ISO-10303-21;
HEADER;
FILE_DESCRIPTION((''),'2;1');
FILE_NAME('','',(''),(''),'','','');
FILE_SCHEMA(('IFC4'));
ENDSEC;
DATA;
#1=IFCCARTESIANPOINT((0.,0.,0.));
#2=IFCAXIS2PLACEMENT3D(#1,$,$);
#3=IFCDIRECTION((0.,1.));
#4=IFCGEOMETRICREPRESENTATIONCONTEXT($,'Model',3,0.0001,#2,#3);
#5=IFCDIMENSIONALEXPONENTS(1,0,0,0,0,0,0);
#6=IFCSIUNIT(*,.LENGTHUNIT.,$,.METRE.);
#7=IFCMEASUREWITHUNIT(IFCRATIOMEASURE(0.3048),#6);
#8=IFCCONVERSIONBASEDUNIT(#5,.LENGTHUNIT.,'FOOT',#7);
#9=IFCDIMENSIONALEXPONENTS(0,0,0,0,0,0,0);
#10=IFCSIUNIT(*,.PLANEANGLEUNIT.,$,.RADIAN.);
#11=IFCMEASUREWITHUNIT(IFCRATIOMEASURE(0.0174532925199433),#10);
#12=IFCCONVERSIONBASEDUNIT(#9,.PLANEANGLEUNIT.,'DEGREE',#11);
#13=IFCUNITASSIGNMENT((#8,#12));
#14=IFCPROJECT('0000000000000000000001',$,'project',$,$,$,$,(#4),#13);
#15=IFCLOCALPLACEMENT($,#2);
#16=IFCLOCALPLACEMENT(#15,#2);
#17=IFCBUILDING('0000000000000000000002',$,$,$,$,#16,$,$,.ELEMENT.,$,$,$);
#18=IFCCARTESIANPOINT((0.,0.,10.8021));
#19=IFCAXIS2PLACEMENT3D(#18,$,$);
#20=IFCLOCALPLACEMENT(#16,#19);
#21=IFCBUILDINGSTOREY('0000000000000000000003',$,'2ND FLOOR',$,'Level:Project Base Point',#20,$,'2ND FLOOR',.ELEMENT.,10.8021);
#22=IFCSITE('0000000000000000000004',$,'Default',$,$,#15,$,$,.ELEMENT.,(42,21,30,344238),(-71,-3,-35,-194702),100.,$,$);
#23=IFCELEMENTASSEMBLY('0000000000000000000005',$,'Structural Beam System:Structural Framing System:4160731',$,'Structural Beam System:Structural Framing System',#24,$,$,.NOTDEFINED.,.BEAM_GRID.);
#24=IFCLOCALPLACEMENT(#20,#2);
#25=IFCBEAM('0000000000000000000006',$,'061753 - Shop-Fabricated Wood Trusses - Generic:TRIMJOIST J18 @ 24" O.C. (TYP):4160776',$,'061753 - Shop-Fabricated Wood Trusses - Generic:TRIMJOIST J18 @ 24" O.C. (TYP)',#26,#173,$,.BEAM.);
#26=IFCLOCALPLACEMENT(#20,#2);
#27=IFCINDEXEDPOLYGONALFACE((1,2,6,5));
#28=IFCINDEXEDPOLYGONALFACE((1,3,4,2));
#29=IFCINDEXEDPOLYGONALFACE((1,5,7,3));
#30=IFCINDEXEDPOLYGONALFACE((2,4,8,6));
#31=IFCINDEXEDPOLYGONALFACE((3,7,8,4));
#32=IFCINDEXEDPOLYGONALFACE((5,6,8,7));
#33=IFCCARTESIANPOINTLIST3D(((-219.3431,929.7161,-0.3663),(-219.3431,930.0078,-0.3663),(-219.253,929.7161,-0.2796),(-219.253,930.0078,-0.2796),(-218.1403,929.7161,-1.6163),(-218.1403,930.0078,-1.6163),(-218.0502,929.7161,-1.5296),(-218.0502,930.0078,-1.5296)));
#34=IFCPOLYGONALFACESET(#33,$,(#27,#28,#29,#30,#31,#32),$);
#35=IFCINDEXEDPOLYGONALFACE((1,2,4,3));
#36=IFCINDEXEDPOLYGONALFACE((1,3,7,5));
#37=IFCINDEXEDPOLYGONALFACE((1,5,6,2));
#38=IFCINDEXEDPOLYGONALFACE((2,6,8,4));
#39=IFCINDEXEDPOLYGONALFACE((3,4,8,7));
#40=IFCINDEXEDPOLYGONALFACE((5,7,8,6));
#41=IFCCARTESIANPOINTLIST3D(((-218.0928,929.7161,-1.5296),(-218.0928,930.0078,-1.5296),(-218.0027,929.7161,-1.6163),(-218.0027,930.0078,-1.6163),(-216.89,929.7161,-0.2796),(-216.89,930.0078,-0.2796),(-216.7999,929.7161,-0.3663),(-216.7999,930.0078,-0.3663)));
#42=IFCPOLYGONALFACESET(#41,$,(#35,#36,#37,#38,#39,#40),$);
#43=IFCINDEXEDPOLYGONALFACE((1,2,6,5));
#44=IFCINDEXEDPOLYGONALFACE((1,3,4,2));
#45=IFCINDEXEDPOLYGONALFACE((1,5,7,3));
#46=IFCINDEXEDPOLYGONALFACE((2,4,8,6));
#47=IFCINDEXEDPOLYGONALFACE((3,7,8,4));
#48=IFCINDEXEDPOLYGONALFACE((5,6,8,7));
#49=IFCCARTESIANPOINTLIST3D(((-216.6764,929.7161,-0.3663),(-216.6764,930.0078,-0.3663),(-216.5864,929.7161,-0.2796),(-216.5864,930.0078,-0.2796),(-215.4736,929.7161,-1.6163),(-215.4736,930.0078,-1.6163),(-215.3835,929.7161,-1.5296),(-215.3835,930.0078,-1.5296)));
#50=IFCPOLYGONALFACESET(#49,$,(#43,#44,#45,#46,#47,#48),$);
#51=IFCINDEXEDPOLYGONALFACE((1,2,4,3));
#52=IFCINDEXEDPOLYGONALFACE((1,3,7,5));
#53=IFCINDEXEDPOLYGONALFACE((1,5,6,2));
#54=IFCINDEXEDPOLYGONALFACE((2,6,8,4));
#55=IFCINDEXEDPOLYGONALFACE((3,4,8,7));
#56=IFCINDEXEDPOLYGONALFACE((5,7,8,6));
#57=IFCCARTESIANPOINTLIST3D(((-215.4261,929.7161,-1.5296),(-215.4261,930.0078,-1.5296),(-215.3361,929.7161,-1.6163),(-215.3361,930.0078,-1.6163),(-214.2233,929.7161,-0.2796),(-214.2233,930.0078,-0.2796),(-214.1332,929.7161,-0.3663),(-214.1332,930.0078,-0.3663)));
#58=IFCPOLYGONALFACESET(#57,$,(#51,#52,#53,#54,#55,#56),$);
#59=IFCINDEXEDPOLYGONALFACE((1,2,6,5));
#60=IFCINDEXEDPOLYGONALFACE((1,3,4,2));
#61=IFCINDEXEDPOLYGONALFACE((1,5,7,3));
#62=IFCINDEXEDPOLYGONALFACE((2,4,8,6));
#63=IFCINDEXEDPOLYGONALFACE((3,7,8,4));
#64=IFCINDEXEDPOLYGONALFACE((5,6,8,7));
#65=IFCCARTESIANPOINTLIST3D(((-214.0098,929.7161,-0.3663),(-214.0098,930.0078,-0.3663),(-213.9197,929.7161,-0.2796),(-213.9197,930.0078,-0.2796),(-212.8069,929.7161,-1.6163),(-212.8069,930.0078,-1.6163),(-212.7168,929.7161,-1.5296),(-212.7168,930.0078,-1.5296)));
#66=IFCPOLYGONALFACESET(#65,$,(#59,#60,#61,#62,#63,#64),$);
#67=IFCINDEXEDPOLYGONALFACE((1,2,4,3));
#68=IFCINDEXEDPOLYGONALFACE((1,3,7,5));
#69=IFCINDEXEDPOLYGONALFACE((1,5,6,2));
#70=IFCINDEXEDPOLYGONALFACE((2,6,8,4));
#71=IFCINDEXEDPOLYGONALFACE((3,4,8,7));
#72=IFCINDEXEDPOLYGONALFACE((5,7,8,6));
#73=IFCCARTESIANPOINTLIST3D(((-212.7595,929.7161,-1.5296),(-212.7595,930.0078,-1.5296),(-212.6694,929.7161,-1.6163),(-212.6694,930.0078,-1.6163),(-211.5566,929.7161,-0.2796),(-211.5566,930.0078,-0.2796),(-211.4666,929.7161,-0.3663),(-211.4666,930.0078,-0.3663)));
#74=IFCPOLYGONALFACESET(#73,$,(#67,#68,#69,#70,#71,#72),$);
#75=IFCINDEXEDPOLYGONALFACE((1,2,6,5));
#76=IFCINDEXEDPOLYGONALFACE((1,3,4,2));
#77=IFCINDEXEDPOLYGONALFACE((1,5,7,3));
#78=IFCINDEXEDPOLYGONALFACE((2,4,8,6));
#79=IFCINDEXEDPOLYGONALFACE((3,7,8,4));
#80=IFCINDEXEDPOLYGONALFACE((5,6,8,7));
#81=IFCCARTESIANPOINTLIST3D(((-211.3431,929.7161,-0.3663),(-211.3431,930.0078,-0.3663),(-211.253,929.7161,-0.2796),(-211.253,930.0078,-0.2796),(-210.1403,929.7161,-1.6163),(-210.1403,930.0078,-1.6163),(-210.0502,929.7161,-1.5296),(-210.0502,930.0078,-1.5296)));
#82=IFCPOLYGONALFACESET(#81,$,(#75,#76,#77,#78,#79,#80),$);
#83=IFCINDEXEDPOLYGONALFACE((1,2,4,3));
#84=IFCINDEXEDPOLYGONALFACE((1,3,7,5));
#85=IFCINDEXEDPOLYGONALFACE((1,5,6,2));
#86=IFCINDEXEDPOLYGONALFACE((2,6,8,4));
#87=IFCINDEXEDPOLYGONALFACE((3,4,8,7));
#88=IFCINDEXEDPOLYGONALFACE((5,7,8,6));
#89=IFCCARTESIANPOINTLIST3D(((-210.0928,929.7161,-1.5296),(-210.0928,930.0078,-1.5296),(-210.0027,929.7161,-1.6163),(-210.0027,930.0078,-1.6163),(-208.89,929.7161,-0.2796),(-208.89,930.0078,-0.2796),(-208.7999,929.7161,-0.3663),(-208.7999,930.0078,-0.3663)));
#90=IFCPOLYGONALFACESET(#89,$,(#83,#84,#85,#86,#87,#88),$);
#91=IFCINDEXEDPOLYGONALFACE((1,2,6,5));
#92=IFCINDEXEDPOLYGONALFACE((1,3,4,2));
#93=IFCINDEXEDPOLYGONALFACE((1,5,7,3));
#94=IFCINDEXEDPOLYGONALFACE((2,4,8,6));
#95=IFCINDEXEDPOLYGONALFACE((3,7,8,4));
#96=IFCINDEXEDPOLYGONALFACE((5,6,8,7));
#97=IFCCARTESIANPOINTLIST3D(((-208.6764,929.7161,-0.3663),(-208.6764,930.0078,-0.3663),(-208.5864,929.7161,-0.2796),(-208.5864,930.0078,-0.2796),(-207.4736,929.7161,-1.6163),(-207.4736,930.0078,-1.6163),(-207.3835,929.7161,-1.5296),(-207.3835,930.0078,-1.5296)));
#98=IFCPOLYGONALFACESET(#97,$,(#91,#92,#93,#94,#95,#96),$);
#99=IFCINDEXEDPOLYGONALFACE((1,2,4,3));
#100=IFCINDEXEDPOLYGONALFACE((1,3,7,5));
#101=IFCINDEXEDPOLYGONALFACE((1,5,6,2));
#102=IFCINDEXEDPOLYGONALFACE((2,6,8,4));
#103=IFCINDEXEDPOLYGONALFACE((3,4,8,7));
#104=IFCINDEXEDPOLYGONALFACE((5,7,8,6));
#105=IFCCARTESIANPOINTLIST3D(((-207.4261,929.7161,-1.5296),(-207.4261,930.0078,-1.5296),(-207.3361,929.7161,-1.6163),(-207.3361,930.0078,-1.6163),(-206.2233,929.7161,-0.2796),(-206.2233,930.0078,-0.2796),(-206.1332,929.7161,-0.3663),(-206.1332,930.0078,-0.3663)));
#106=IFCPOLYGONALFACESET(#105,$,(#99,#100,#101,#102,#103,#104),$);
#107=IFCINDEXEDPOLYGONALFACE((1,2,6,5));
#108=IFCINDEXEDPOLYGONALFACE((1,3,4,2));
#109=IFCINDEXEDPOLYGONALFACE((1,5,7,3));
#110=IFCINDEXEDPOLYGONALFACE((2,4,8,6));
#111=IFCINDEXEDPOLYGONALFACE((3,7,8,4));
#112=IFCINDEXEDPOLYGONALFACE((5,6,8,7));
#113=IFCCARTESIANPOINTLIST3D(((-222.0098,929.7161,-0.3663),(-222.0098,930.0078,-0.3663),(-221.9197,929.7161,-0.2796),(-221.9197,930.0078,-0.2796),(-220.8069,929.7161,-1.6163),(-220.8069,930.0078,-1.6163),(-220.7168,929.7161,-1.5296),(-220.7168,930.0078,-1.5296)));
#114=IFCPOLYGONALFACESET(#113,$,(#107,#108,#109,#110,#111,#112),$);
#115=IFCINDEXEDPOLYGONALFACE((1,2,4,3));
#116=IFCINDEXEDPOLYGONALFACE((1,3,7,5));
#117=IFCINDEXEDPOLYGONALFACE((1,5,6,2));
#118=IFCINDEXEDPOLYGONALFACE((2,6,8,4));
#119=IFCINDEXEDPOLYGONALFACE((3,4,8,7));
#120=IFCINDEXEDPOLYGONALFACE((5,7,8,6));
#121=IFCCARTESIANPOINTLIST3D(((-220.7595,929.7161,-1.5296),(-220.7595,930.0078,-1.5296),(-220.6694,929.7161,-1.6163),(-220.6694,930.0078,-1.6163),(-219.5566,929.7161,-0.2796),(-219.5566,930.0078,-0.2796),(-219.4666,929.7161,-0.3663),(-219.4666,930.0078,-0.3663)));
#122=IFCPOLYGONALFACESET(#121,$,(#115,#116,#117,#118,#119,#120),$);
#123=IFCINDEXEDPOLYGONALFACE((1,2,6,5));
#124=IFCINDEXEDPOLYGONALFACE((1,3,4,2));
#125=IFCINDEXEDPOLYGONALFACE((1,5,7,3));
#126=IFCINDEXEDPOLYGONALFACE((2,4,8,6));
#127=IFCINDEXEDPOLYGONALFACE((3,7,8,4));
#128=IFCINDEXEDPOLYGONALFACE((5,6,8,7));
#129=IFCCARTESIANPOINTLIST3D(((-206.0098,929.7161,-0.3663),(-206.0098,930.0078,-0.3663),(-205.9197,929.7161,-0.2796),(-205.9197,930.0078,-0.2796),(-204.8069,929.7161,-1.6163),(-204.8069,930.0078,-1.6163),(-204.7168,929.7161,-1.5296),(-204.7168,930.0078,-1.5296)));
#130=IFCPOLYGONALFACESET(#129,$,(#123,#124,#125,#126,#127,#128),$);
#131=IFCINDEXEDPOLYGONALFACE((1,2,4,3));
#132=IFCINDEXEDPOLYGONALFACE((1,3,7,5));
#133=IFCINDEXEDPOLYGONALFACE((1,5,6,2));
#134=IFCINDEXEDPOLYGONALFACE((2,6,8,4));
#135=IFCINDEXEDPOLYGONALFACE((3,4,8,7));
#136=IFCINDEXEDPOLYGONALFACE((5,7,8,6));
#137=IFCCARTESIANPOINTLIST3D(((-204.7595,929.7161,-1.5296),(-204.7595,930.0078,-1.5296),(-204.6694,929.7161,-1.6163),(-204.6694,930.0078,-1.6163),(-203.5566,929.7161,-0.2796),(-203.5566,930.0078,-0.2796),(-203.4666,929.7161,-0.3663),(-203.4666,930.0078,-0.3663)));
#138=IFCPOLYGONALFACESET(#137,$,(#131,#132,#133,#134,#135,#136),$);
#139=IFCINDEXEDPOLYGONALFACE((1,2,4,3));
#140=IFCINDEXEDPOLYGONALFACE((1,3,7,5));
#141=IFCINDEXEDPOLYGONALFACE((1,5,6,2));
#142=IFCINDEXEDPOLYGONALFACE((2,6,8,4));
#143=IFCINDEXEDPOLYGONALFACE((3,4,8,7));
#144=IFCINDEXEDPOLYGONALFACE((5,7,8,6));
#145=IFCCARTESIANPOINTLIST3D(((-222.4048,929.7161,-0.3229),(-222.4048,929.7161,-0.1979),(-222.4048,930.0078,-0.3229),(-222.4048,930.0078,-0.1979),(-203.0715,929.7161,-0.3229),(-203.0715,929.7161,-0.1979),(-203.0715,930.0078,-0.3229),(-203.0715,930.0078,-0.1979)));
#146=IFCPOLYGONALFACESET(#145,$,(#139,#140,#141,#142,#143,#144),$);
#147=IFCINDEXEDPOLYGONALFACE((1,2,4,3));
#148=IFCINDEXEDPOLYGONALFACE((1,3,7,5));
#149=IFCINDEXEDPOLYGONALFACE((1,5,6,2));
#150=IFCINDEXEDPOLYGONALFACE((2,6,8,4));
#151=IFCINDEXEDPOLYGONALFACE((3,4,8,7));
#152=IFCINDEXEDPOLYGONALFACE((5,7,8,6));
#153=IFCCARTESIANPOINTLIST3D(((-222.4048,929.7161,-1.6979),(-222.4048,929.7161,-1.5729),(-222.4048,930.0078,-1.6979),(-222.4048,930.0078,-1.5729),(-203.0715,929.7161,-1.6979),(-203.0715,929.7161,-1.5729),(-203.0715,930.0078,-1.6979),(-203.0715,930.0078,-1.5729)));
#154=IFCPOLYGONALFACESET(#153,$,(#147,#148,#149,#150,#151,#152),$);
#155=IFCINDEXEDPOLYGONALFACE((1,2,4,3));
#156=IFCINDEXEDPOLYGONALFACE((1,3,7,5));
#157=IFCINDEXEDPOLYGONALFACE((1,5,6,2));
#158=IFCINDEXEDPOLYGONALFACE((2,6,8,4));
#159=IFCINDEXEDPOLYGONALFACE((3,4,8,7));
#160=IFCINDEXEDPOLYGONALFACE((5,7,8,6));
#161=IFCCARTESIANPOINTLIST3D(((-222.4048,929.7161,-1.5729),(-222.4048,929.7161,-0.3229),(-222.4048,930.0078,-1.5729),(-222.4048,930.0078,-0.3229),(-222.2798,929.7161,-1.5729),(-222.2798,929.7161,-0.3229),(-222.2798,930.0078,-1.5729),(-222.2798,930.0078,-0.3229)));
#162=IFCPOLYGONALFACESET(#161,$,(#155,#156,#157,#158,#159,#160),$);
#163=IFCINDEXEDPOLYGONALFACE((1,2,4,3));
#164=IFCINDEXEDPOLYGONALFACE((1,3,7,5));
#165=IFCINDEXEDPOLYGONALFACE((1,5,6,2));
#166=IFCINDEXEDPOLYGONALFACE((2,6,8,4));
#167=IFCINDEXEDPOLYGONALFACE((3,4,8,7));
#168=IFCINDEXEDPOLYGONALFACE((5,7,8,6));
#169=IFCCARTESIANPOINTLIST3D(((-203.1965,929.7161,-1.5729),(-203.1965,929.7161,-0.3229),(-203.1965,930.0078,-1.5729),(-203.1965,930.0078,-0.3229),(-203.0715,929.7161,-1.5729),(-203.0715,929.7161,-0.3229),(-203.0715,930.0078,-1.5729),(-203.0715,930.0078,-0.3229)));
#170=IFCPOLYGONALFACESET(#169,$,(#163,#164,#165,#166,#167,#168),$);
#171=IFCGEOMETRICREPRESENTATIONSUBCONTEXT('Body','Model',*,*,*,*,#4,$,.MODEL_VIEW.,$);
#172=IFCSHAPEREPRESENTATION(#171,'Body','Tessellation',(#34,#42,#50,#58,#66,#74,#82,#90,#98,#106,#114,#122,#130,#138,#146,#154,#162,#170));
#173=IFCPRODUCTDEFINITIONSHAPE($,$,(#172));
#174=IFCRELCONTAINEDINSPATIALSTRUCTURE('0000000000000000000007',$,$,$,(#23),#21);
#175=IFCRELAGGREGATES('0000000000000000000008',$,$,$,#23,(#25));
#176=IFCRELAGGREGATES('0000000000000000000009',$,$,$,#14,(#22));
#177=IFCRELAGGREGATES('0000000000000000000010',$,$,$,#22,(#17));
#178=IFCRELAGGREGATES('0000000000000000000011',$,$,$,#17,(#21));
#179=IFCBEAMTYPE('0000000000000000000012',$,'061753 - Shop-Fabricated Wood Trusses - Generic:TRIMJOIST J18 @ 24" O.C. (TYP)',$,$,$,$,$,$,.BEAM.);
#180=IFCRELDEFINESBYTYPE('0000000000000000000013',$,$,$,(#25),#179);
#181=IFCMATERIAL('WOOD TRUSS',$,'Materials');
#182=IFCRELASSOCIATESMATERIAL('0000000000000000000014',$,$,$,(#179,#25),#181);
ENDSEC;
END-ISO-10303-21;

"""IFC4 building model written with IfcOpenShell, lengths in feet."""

from ifc_helpers import new_model, entity, si_unit, converted_unit, direction, frame, frame_2d, origin, origin_2d_with_axis, place, context, subcontext, project, spatial, rectangle, extrude, source, transform, mapped, material, material_profile, profile_set, profile_usage, type_object, type_shapes, element, aggregate, save


model = new_model("IFC4")

# Units and contexts
model_context = context("Model", 3, precision=0.0001, world=origin(), true_north=direction((0.0, 1.0)))
body_context = subcontext(model_context, "Body", "Model", "MODEL_VIEW")
ifc_project = project(units=[converted_unit("LENGTHUNIT", "FOOT", entity("IfcRatioMeasure", 0.3048), si_unit("LENGTHUNIT", "METRE"), dimensions=[1, 0, 0, 0, 0, 0, 0]), converted_unit("PLANEANGLEUNIT", "DEGREE", entity("IfcRatioMeasure", 0.0174532925199433), si_unit("PLANEANGLEUNIT", "RADIAN"), dimensions=[0, 0, 0, 0, 0, 0, 0])], contexts=[model_context])

# Site, building, storey
site_placement = place(None, origin())
site = spatial("IfcSite", under=ifc_project, at=site_placement, Name="Default", CompositionType="ELEMENT", RefLatitude=(42, 21, 30, 344238), RefLongitude=(-71, -3, -35, -194702), RefElevation=100.0)
building_placement = place(site_placement, origin())
building = spatial("IfcBuilding", under=site, at=building_placement, CompositionType="ELEMENT")
storey_placement = place(building_placement, frame((0.0, 0.0, 10.8021)))
storey = spatial("IfcBuildingStorey", under=building, at=storey_placement, Name="2ND FLOOR", ObjectType="Level:Project Base Point", LongName="2ND FLOOR", CompositionType="ELEMENT", Elevation=10.8021)

# Element assembly, beam
ifc_material_1 = material(Name="WOOD TRUSS", Category="Materials")
ifc_material_profile_1 = material_profile(ifc_material_1, rectangle(XDim=1.7347, YDim=0.125, at=frame_2d((0.0, 0.0), x_axis=(1.0, 0.0))), Name="TRIMJOIST J18 @ 24\" O.C. (TYP)")
ifc_material_profile_2 = material_profile(ifc_material_1, rectangle(XDim=1.7347, YDim=0.125, at=frame_2d((0.0, 0.0), x_axis=(1.0, 0.0))), Name="TRIMJOIST J18 @ 24\" O.C. (TYP)")
ifc_material_profile_3 = material_profile(ifc_material_1, rectangle(XDim=1.7347, YDim=0.125, at=frame_2d((0.0, 0.0), x_axis=(1.0, 0.0))), Name="TRIMJOIST J18 @ 24\" O.C. (TYP)")
ifc_material_profile_4 = material_profile(ifc_material_1, rectangle(XDim=1.7347, YDim=0.125, at=frame_2d((0.0, 0.0), x_axis=(1.0, 0.0))), Name="TRIMJOIST J18 @ 24\" O.C. (TYP)")
ifc_material_profile_5 = material_profile(ifc_material_1, rectangle(XDim=1.7347, YDim=0.125, at=frame_2d((0.0, 0.0), x_axis=(1.0, 0.0))), Name="TRIMJOIST J18 @ 24\" O.C. (TYP)")
ifc_material_profile_6 = material_profile(ifc_material_1, rectangle(XDim=1.7347, YDim=0.125, at=frame_2d((0.0, 0.0), x_axis=(1.0, 0.0))), Name="TRIMJOIST J18 @ 24\" O.C. (TYP)")
ifc_material_profile_7 = material_profile(ifc_material_1, rectangle(XDim=1.7347, YDim=0.125, at=frame_2d((0.0, 0.0), x_axis=(1.0, 0.0))), Name="TRIMJOIST J18 @ 24\" O.C. (TYP)")
ifc_material_profile_8 = material_profile(ifc_material_1, rectangle(XDim=1.7347, YDim=0.125, at=frame_2d((0.0, 0.0), x_axis=(1.0, 0.0))), Name="TRIMJOIST J18 @ 24\" O.C. (TYP)")
ifc_material_profile_9 = material_profile(ifc_material_1, rectangle(XDim=1.7347, YDim=0.125, at=frame_2d((0.0, 0.0), x_axis=(1.0, 0.0))), Name="TRIMJOIST J18 @ 24\" O.C. (TYP)")
ifc_material_profile_10 = material_profile(ifc_material_1, rectangle(XDim=1.7347, YDim=0.125, at=origin_2d_with_axis()), Name="TRIMJOIST J18 @ 24\" O.C. (TYP)")
ifc_material_profile_11 = material_profile(ifc_material_1, rectangle(XDim=0.125, YDim=0.2917, at=origin_2d_with_axis()), Name="TRIMJOIST J18 @ 24\" O.C. (TYP)")
ifc_material_profile_12 = material_profile(ifc_material_1, rectangle(XDim=0.125, YDim=0.2917, at=origin_2d_with_axis()), Name="TRIMJOIST J18 @ 24\" O.C. (TYP)")
ifc_material_profile_13 = material_profile(ifc_material_1, rectangle(XDim=1.25, YDim=0.2917, at=origin_2d_with_axis()), Name="TRIMJOIST J18 @ 24\" O.C. (TYP)")
ifc_material_profile_14 = material_profile(ifc_material_1, rectangle(XDim=1.25, YDim=0.2917, at=origin_2d_with_axis()), Name="TRIMJOIST J18 @ 24\" O.C. (TYP)")
ifc_profile_set_1 = profile_set([ifc_material_profile_1, ifc_material_profile_2, ifc_material_profile_3, ifc_material_profile_4, ifc_material_profile_5, ifc_material_profile_6, ifc_material_profile_7, ifc_material_profile_8, ifc_material_profile_9, ifc_material_profile_10, ifc_material_profile_11, ifc_material_profile_12, ifc_material_profile_13, ifc_material_profile_14], Name="TRIMJOIST J18 @ 24\" O.C. (TYP)")
beam_type_1 = type_object("IfcBeamType", Name="061753 - Shop-Fabricated Wood Trusses - Generic:TRIMJOIST J18 @ 24\" O.C. (TYP)", PredefinedType="BEAM", material=ifc_profile_set_1)
shared_shape_1 = source(origin(), body_context, "Body", "SweptSolid", [
    extrude(rectangle(XDim=1.7347, YDim=0.125, at=frame_2d((0.0, 0.0), x_axis=(1.0, 0.0))), frame((5.9585, -0.1458, 0.0), z_axis=(0.0, 1.0, 0.0), x_axis=(0.693383, 0.0, 0.720569)), (0.0, 0.0, 1.0), 0.2917),
    extrude(rectangle(XDim=1.7347, YDim=0.125, at=origin_2d_with_axis()), frame((4.7082, -0.1458, 0.0), z_axis=(0.0, 1.0, 0.0), x_axis=(0.693383, 0.0, -0.720569)), (0.0, 0.0, 1.0), 0.2917),
    extrude(rectangle(XDim=1.7347, YDim=0.125, at=frame_2d((0.0, 0.0), x_axis=(1.0, 0.0))), frame((3.2918, -0.1458, 0.0), z_axis=(0.0, 1.0, 0.0), x_axis=(0.693383, 0.0, 0.720569)), (0.0, 0.0, 1.0), 0.2917),
    extrude(rectangle(XDim=1.7347, YDim=0.125, at=frame_2d((0.0, 0.0), x_axis=(1.0, 0.0))), frame((2.0415, -0.1458, 0.0), z_axis=(0.0, 1.0, 0.0), x_axis=(0.693383, 0.0, -0.720569)), (0.0, 0.0, 1.0), 0.2917),
    extrude(rectangle(XDim=1.7347, YDim=0.125, at=frame_2d((0.0, 0.0), x_axis=(1.0, 0.0))), frame((0.6251, -0.1458, 0.0), z_axis=(0.0, 1.0, 0.0), x_axis=(0.693383, 0.0, 0.720569)), (0.0, 0.0, 1.0), 0.2917),
    extrude(rectangle(XDim=1.7347, YDim=0.125, at=frame_2d((0.0, 0.0), x_axis=(1.0, 0.0))), frame((-0.6251, -0.1458, 0.0), z_axis=(0.0, 1.0, 0.0), x_axis=(0.693383, 0.0, -0.720569)), (0.0, 0.0, 1.0), 0.2917),
    extrude(rectangle(XDim=1.7347, YDim=0.125, at=frame_2d((0.0, 0.0), x_axis=(1.0, 0.0))), frame((-2.0415, -0.1458, 0.0), z_axis=(0.0, 1.0, 0.0), x_axis=(0.693383, 0.0, 0.720569)), (0.0, 0.0, 1.0), 0.2917),
    extrude(rectangle(XDim=1.7347, YDim=0.125, at=origin_2d_with_axis()), frame((-3.2918, -0.1458, 0.0), z_axis=(0.0, 1.0, 0.0), x_axis=(0.693383, 0.0, -0.720569)), (0.0, 0.0, 1.0), 0.2917),
    extrude(rectangle(XDim=1.7347, YDim=0.125, at=frame_2d((0.0, 0.0), x_axis=(1.0, 0.0))), frame((-4.7082, -0.1458, 0.0), z_axis=(0.0, 1.0, 0.0), x_axis=(0.693383, 0.0, 0.720569)), (0.0, 0.0, 1.0), 0.2917),
    extrude(rectangle(XDim=1.7347, YDim=0.125, at=frame_2d((0.0, 0.0), x_axis=(1.0, 0.0))), frame((-5.9585, -0.1458, 0.0), z_axis=(0.0, 1.0, 0.0), x_axis=(0.693383, 0.0, -0.720569)), (0.0, 0.0, 1.0), 0.2917),
    extrude(rectangle(XDim=1.7347, YDim=0.125, at=frame_2d((0.0, 0.0), x_axis=(1.0, 0.0))), frame((8.6251, -0.1458, 0.0), z_axis=(0.0, 1.0, 0.0), x_axis=(0.693383, 0.0, 0.720569)), (0.0, 0.0, 1.0), 0.2917),
    extrude(rectangle(XDim=1.7347, YDim=0.125, at=origin_2d_with_axis()), frame((7.3749, -0.1458, 0.0), z_axis=(0.0, 1.0, 0.0), x_axis=(0.693383, 0.0, -0.720569)), (0.0, 0.0, 1.0), 0.2917),
    extrude(rectangle(XDim=1.7347, YDim=0.125, at=frame_2d((0.0, 0.0), x_axis=(1.0, 0.0))), frame((-7.3749, -0.1458, 0.0), z_axis=(0.0, 1.0, 0.0), x_axis=(0.693383, 0.0, 0.720569)), (0.0, 0.0, 1.0), 0.2917),
    extrude(rectangle(XDim=1.7347, YDim=0.125, at=origin_2d_with_axis()), frame((-8.6251, -0.1458, 0.0), z_axis=(0.0, 1.0, 0.0), x_axis=(0.693383, 0.0, -0.720569)), (0.0, 0.0, 1.0), 0.2917),
    extrude(rectangle(XDim=0.125, YDim=0.2917, at=origin_2d_with_axis()), frame((-9.6667, 0.0, 0.6875), z_axis=(1.0, 0.0, 0.0), x_axis=(0.0, 0.0, -1.0)), (0.0, 0.0, 1.0), 19.3333),
    extrude(rectangle(XDim=0.125, YDim=0.2917, at=origin_2d_with_axis()), frame((-9.6667, 0.0, -0.6875), z_axis=(1.0, 0.0, 0.0), x_axis=(0.0, 0.0, -1.0)), (0.0, 0.0, 1.0), 19.3333),
    extrude(rectangle(XDim=1.25, YDim=0.2917, at=origin_2d_with_axis()), frame((9.5417, 0.0, 0.0), z_axis=(1.0, 0.0, 0.0), x_axis=(0.0, 0.0, -1.0)), (0.0, 0.0, 1.0), 0.125),
    extrude(rectangle(XDim=1.25, YDim=0.2917, at=origin_2d_with_axis()), frame((-9.6667, 0.0, 0.0), z_axis=(1.0, 0.0, 0.0), x_axis=(0.0, 0.0, -1.0)), (0.0, 0.0, 1.0), 0.125),
])
type_shapes(beam_type_1, [shared_shape_1])
assembly_1_placement = place(storey_placement, origin())
assembly_1 = element("IfcElementAssembly", 1, at=assembly_1_placement, inside=storey, Name="Structural Beam System:Structural Framing System:4160731", ObjectType="Structural Beam System:Structural Framing System", AssemblyPlace="NOTDEFINED", PredefinedType="BEAM_GRID")
ifc_profile_usage_1 = profile_usage(ifc_profile_set_1, cardinal=8)
beam_1_placement = place(assembly_1_placement, frame((-212.7382, 929.8619, -0.9479), z_axis=(0.0, 0.0, 1.0), x_axis=(-1.0, 0.0, 0.0)))
beam_1 = element("IfcBeam", 2, at=beam_1_placement, type_object=beam_type_1, material=ifc_profile_usage_1, Name="061753 - Shop-Fabricated Wood Trusses - Generic:TRIMJOIST J18 @ 24\" O.C. (TYP):4160776", ObjectType="061753 - Shop-Fabricated Wood Trusses - Generic:TRIMJOIST J18 @ 24\" O.C. (TYP)", PredefinedType="BEAM", context=body_context, shape_type="MappedRepresentation", body=[
    mapped(shared_shape_1, transform((0.0, 0.0, 0.0), scale=1.0)),
])
aggregate(assembly_1, [beam_1])

save(model, "model.ifc")
